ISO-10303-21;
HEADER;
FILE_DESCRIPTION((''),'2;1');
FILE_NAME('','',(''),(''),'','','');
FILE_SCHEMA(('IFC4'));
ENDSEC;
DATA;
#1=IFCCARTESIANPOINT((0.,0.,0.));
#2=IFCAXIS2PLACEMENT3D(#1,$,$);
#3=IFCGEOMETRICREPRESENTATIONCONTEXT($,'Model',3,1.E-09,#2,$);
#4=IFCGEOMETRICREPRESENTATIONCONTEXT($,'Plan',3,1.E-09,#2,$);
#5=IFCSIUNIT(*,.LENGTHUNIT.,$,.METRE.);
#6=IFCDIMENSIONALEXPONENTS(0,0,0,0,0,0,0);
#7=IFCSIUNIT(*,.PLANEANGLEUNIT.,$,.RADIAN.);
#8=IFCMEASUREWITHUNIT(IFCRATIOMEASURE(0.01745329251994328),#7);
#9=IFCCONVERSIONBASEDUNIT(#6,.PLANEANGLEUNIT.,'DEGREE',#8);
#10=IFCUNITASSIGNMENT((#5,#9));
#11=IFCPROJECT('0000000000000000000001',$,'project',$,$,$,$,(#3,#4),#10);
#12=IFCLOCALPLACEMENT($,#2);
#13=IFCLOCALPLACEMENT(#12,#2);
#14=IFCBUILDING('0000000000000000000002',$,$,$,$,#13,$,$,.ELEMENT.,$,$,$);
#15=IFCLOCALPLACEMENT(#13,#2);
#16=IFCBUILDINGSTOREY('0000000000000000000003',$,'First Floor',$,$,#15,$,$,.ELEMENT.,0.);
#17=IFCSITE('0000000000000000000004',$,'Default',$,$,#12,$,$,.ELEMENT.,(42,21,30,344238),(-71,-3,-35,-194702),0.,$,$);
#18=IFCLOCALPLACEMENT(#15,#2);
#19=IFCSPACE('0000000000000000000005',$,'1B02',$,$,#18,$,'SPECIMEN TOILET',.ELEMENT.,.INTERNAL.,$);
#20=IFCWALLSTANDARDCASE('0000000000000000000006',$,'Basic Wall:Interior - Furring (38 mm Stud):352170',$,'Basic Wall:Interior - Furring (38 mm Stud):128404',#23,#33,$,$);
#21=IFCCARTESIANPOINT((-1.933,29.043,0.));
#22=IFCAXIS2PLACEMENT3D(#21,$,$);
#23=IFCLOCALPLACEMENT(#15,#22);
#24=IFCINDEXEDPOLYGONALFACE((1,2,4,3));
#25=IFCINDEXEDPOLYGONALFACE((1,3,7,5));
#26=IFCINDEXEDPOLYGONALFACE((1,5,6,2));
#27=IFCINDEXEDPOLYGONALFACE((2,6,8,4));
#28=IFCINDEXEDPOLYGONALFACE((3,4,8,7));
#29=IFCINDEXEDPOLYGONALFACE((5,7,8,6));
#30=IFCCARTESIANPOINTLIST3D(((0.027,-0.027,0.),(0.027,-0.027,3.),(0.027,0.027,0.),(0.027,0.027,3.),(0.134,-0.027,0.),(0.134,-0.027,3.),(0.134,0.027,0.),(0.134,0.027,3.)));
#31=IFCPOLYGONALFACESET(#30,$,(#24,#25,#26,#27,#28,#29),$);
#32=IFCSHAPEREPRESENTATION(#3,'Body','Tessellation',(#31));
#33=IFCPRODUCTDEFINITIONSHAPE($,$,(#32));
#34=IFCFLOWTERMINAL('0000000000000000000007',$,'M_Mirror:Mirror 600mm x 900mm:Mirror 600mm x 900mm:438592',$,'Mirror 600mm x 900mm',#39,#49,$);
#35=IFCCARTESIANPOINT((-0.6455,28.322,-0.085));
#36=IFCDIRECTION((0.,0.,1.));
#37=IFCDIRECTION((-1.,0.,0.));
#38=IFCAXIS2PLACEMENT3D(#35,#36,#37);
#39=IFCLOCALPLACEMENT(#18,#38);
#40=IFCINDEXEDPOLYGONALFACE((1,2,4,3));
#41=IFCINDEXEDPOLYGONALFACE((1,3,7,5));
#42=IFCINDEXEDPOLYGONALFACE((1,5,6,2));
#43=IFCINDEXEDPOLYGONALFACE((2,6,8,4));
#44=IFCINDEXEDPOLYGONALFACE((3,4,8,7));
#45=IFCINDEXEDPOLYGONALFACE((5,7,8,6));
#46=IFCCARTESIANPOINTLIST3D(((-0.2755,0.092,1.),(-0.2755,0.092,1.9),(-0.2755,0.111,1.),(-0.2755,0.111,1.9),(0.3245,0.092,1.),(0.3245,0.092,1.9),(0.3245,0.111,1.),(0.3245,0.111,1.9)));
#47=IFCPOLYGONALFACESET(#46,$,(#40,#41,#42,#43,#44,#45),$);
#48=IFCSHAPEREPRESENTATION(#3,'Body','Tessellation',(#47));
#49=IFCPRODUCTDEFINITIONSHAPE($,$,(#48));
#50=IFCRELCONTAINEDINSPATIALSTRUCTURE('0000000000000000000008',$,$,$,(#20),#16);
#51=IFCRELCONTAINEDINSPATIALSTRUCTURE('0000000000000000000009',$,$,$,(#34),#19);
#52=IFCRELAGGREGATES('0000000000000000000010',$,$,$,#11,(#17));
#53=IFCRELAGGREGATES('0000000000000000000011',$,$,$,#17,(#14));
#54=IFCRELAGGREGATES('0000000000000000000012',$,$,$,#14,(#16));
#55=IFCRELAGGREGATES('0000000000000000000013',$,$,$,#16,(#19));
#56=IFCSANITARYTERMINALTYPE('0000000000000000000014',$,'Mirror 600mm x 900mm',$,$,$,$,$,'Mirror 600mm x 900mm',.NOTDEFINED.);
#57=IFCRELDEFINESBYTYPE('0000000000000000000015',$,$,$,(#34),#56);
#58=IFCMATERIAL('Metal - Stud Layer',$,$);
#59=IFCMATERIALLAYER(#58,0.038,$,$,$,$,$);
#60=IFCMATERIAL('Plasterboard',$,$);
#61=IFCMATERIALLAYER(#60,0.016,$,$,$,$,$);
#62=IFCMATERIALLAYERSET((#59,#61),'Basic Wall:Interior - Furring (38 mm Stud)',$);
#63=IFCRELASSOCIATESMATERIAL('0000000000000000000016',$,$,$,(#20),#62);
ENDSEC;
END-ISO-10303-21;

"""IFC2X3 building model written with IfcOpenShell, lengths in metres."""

from ifc_helpers import new_model, entity, si_unit, converted_unit, frame, frame_2d, origin, origin_2d_with_axis, place, context, project, spatial, rectangle, extrude, source, transform, mapped, material, layer, layer_set, layer_usage, type_object, type_shapes, element, save


model = new_model("IFC2X3")

# Units and contexts
model_context = context("Model", 3, precision=1e-09, world=origin())
plan_context = context("Plan", 3, precision=1e-09, world=origin())
ifc_project = project(units=[si_unit("LENGTHUNIT", "METRE"), converted_unit("PLANEANGLEUNIT", "DEGREE", entity("IfcRatioMeasure", 0.01745329251994328), si_unit("PLANEANGLEUNIT", "RADIAN"), dimensions=[0, 0, 0, 0, 0, 0, 0])], contexts=[model_context, plan_context])

# Site, building, storey
site_placement = place(None, origin())
site = spatial("IfcSite", under=ifc_project, at=site_placement, Name="Default", CompositionType="ELEMENT", RefLatitude=(42, 21, 30, 344238), RefLongitude=(-71, -3, -35, -194702), RefElevation=0.0)
building_placement = place(site_placement, origin())
building = spatial("IfcBuilding", under=site, at=building_placement, CompositionType="ELEMENT")
storey_placement = place(building_placement, origin())
storey = spatial("IfcBuildingStorey", under=building, at=storey_placement, Name="First Floor", CompositionType="ELEMENT", Elevation=0.0)

# Shared definitions
ifc_material_1 = material(Name="Plasterboard")
ifc_material_2 = material(Name="Metal - Stud Layer")

# Wall
ifc_layer_1 = layer(ifc_material_2, 0.038)
ifc_layer_2 = layer(ifc_material_1, 0.016)
ifc_layer_set_1 = layer_set([ifc_layer_1, ifc_layer_2], Name="Basic Wall:Interior - Furring (38 mm Stud)")
ifc_layer_usage_1 = layer_usage(ifc_layer_set_1, "AXIS2", "POSITIVE", -0.027)
wall_1_placement = place(storey_placement, frame((-1.933, 29.043, 0.0)))
element("IfcWallStandardCase", 1, at=wall_1_placement, inside=storey, material=ifc_layer_usage_1, Name="Basic Wall:Interior - Furring (38 mm Stud):352170", ObjectType="Basic Wall:Interior - Furring (38 mm Stud):128404", context=model_context, shape_type="SweptSolid", body=[
    extrude(rectangle(XDim=0.107, YDim=0.054, at=frame_2d((0.0805, 0.0), x_axis=(-1.0, 0.0))), origin(), (0.0, 0.0, 1.0), 3.0),
])

# Shared definitions
space_1_placement = place(storey_placement, origin())
space_1 = spatial("IfcSpace", under=storey, at=space_1_placement, Name="1B02", LongName="SPECIMEN TOILET", CompositionType="ELEMENT", InteriorOrExteriorSpace="INTERNAL")

# Flow terminal
sanitary_terminal_type = type_object("IfcSanitaryTerminalType", Name="Mirror 600mm x 900mm", ElementType="Mirror 600mm x 900mm", PredefinedType="NOTDEFINED")
shared_shape_1 = source(origin(), model_context, "Body", "SweptSolid", [
    extrude(rectangle(XDim=0.0191, YDim=0.6, at=origin_2d_with_axis()), frame((0.0245, 0.1015, 1.0), z_axis=(0.0, 0.0, 1.0), x_axis=(0.0, -1.0, 0.0)), (0.0, 0.0, 1.0), 0.9),
])
type_shapes(sanitary_terminal_type, [shared_shape_1])
flow_terminal_placement = place(space_1_placement, frame((-0.6455, 28.322, -0.085), z_axis=(0.0, 0.0, 1.0), x_axis=(-1.0, 0.0, 0.0)))
element("IfcFlowTerminal", 2, at=flow_terminal_placement, inside=space_1, type_object=sanitary_terminal_type, Name="M_Mirror:Mirror 600mm x 900mm:Mirror 600mm x 900mm:438592", ObjectType="Mirror 600mm x 900mm", context=model_context, shape_type="MappedRepresentation", body=[
    mapped(shared_shape_1, transform((0.0, 0.0, 0.0), scale=1.0)),
])

save(model, "model.ifc")
